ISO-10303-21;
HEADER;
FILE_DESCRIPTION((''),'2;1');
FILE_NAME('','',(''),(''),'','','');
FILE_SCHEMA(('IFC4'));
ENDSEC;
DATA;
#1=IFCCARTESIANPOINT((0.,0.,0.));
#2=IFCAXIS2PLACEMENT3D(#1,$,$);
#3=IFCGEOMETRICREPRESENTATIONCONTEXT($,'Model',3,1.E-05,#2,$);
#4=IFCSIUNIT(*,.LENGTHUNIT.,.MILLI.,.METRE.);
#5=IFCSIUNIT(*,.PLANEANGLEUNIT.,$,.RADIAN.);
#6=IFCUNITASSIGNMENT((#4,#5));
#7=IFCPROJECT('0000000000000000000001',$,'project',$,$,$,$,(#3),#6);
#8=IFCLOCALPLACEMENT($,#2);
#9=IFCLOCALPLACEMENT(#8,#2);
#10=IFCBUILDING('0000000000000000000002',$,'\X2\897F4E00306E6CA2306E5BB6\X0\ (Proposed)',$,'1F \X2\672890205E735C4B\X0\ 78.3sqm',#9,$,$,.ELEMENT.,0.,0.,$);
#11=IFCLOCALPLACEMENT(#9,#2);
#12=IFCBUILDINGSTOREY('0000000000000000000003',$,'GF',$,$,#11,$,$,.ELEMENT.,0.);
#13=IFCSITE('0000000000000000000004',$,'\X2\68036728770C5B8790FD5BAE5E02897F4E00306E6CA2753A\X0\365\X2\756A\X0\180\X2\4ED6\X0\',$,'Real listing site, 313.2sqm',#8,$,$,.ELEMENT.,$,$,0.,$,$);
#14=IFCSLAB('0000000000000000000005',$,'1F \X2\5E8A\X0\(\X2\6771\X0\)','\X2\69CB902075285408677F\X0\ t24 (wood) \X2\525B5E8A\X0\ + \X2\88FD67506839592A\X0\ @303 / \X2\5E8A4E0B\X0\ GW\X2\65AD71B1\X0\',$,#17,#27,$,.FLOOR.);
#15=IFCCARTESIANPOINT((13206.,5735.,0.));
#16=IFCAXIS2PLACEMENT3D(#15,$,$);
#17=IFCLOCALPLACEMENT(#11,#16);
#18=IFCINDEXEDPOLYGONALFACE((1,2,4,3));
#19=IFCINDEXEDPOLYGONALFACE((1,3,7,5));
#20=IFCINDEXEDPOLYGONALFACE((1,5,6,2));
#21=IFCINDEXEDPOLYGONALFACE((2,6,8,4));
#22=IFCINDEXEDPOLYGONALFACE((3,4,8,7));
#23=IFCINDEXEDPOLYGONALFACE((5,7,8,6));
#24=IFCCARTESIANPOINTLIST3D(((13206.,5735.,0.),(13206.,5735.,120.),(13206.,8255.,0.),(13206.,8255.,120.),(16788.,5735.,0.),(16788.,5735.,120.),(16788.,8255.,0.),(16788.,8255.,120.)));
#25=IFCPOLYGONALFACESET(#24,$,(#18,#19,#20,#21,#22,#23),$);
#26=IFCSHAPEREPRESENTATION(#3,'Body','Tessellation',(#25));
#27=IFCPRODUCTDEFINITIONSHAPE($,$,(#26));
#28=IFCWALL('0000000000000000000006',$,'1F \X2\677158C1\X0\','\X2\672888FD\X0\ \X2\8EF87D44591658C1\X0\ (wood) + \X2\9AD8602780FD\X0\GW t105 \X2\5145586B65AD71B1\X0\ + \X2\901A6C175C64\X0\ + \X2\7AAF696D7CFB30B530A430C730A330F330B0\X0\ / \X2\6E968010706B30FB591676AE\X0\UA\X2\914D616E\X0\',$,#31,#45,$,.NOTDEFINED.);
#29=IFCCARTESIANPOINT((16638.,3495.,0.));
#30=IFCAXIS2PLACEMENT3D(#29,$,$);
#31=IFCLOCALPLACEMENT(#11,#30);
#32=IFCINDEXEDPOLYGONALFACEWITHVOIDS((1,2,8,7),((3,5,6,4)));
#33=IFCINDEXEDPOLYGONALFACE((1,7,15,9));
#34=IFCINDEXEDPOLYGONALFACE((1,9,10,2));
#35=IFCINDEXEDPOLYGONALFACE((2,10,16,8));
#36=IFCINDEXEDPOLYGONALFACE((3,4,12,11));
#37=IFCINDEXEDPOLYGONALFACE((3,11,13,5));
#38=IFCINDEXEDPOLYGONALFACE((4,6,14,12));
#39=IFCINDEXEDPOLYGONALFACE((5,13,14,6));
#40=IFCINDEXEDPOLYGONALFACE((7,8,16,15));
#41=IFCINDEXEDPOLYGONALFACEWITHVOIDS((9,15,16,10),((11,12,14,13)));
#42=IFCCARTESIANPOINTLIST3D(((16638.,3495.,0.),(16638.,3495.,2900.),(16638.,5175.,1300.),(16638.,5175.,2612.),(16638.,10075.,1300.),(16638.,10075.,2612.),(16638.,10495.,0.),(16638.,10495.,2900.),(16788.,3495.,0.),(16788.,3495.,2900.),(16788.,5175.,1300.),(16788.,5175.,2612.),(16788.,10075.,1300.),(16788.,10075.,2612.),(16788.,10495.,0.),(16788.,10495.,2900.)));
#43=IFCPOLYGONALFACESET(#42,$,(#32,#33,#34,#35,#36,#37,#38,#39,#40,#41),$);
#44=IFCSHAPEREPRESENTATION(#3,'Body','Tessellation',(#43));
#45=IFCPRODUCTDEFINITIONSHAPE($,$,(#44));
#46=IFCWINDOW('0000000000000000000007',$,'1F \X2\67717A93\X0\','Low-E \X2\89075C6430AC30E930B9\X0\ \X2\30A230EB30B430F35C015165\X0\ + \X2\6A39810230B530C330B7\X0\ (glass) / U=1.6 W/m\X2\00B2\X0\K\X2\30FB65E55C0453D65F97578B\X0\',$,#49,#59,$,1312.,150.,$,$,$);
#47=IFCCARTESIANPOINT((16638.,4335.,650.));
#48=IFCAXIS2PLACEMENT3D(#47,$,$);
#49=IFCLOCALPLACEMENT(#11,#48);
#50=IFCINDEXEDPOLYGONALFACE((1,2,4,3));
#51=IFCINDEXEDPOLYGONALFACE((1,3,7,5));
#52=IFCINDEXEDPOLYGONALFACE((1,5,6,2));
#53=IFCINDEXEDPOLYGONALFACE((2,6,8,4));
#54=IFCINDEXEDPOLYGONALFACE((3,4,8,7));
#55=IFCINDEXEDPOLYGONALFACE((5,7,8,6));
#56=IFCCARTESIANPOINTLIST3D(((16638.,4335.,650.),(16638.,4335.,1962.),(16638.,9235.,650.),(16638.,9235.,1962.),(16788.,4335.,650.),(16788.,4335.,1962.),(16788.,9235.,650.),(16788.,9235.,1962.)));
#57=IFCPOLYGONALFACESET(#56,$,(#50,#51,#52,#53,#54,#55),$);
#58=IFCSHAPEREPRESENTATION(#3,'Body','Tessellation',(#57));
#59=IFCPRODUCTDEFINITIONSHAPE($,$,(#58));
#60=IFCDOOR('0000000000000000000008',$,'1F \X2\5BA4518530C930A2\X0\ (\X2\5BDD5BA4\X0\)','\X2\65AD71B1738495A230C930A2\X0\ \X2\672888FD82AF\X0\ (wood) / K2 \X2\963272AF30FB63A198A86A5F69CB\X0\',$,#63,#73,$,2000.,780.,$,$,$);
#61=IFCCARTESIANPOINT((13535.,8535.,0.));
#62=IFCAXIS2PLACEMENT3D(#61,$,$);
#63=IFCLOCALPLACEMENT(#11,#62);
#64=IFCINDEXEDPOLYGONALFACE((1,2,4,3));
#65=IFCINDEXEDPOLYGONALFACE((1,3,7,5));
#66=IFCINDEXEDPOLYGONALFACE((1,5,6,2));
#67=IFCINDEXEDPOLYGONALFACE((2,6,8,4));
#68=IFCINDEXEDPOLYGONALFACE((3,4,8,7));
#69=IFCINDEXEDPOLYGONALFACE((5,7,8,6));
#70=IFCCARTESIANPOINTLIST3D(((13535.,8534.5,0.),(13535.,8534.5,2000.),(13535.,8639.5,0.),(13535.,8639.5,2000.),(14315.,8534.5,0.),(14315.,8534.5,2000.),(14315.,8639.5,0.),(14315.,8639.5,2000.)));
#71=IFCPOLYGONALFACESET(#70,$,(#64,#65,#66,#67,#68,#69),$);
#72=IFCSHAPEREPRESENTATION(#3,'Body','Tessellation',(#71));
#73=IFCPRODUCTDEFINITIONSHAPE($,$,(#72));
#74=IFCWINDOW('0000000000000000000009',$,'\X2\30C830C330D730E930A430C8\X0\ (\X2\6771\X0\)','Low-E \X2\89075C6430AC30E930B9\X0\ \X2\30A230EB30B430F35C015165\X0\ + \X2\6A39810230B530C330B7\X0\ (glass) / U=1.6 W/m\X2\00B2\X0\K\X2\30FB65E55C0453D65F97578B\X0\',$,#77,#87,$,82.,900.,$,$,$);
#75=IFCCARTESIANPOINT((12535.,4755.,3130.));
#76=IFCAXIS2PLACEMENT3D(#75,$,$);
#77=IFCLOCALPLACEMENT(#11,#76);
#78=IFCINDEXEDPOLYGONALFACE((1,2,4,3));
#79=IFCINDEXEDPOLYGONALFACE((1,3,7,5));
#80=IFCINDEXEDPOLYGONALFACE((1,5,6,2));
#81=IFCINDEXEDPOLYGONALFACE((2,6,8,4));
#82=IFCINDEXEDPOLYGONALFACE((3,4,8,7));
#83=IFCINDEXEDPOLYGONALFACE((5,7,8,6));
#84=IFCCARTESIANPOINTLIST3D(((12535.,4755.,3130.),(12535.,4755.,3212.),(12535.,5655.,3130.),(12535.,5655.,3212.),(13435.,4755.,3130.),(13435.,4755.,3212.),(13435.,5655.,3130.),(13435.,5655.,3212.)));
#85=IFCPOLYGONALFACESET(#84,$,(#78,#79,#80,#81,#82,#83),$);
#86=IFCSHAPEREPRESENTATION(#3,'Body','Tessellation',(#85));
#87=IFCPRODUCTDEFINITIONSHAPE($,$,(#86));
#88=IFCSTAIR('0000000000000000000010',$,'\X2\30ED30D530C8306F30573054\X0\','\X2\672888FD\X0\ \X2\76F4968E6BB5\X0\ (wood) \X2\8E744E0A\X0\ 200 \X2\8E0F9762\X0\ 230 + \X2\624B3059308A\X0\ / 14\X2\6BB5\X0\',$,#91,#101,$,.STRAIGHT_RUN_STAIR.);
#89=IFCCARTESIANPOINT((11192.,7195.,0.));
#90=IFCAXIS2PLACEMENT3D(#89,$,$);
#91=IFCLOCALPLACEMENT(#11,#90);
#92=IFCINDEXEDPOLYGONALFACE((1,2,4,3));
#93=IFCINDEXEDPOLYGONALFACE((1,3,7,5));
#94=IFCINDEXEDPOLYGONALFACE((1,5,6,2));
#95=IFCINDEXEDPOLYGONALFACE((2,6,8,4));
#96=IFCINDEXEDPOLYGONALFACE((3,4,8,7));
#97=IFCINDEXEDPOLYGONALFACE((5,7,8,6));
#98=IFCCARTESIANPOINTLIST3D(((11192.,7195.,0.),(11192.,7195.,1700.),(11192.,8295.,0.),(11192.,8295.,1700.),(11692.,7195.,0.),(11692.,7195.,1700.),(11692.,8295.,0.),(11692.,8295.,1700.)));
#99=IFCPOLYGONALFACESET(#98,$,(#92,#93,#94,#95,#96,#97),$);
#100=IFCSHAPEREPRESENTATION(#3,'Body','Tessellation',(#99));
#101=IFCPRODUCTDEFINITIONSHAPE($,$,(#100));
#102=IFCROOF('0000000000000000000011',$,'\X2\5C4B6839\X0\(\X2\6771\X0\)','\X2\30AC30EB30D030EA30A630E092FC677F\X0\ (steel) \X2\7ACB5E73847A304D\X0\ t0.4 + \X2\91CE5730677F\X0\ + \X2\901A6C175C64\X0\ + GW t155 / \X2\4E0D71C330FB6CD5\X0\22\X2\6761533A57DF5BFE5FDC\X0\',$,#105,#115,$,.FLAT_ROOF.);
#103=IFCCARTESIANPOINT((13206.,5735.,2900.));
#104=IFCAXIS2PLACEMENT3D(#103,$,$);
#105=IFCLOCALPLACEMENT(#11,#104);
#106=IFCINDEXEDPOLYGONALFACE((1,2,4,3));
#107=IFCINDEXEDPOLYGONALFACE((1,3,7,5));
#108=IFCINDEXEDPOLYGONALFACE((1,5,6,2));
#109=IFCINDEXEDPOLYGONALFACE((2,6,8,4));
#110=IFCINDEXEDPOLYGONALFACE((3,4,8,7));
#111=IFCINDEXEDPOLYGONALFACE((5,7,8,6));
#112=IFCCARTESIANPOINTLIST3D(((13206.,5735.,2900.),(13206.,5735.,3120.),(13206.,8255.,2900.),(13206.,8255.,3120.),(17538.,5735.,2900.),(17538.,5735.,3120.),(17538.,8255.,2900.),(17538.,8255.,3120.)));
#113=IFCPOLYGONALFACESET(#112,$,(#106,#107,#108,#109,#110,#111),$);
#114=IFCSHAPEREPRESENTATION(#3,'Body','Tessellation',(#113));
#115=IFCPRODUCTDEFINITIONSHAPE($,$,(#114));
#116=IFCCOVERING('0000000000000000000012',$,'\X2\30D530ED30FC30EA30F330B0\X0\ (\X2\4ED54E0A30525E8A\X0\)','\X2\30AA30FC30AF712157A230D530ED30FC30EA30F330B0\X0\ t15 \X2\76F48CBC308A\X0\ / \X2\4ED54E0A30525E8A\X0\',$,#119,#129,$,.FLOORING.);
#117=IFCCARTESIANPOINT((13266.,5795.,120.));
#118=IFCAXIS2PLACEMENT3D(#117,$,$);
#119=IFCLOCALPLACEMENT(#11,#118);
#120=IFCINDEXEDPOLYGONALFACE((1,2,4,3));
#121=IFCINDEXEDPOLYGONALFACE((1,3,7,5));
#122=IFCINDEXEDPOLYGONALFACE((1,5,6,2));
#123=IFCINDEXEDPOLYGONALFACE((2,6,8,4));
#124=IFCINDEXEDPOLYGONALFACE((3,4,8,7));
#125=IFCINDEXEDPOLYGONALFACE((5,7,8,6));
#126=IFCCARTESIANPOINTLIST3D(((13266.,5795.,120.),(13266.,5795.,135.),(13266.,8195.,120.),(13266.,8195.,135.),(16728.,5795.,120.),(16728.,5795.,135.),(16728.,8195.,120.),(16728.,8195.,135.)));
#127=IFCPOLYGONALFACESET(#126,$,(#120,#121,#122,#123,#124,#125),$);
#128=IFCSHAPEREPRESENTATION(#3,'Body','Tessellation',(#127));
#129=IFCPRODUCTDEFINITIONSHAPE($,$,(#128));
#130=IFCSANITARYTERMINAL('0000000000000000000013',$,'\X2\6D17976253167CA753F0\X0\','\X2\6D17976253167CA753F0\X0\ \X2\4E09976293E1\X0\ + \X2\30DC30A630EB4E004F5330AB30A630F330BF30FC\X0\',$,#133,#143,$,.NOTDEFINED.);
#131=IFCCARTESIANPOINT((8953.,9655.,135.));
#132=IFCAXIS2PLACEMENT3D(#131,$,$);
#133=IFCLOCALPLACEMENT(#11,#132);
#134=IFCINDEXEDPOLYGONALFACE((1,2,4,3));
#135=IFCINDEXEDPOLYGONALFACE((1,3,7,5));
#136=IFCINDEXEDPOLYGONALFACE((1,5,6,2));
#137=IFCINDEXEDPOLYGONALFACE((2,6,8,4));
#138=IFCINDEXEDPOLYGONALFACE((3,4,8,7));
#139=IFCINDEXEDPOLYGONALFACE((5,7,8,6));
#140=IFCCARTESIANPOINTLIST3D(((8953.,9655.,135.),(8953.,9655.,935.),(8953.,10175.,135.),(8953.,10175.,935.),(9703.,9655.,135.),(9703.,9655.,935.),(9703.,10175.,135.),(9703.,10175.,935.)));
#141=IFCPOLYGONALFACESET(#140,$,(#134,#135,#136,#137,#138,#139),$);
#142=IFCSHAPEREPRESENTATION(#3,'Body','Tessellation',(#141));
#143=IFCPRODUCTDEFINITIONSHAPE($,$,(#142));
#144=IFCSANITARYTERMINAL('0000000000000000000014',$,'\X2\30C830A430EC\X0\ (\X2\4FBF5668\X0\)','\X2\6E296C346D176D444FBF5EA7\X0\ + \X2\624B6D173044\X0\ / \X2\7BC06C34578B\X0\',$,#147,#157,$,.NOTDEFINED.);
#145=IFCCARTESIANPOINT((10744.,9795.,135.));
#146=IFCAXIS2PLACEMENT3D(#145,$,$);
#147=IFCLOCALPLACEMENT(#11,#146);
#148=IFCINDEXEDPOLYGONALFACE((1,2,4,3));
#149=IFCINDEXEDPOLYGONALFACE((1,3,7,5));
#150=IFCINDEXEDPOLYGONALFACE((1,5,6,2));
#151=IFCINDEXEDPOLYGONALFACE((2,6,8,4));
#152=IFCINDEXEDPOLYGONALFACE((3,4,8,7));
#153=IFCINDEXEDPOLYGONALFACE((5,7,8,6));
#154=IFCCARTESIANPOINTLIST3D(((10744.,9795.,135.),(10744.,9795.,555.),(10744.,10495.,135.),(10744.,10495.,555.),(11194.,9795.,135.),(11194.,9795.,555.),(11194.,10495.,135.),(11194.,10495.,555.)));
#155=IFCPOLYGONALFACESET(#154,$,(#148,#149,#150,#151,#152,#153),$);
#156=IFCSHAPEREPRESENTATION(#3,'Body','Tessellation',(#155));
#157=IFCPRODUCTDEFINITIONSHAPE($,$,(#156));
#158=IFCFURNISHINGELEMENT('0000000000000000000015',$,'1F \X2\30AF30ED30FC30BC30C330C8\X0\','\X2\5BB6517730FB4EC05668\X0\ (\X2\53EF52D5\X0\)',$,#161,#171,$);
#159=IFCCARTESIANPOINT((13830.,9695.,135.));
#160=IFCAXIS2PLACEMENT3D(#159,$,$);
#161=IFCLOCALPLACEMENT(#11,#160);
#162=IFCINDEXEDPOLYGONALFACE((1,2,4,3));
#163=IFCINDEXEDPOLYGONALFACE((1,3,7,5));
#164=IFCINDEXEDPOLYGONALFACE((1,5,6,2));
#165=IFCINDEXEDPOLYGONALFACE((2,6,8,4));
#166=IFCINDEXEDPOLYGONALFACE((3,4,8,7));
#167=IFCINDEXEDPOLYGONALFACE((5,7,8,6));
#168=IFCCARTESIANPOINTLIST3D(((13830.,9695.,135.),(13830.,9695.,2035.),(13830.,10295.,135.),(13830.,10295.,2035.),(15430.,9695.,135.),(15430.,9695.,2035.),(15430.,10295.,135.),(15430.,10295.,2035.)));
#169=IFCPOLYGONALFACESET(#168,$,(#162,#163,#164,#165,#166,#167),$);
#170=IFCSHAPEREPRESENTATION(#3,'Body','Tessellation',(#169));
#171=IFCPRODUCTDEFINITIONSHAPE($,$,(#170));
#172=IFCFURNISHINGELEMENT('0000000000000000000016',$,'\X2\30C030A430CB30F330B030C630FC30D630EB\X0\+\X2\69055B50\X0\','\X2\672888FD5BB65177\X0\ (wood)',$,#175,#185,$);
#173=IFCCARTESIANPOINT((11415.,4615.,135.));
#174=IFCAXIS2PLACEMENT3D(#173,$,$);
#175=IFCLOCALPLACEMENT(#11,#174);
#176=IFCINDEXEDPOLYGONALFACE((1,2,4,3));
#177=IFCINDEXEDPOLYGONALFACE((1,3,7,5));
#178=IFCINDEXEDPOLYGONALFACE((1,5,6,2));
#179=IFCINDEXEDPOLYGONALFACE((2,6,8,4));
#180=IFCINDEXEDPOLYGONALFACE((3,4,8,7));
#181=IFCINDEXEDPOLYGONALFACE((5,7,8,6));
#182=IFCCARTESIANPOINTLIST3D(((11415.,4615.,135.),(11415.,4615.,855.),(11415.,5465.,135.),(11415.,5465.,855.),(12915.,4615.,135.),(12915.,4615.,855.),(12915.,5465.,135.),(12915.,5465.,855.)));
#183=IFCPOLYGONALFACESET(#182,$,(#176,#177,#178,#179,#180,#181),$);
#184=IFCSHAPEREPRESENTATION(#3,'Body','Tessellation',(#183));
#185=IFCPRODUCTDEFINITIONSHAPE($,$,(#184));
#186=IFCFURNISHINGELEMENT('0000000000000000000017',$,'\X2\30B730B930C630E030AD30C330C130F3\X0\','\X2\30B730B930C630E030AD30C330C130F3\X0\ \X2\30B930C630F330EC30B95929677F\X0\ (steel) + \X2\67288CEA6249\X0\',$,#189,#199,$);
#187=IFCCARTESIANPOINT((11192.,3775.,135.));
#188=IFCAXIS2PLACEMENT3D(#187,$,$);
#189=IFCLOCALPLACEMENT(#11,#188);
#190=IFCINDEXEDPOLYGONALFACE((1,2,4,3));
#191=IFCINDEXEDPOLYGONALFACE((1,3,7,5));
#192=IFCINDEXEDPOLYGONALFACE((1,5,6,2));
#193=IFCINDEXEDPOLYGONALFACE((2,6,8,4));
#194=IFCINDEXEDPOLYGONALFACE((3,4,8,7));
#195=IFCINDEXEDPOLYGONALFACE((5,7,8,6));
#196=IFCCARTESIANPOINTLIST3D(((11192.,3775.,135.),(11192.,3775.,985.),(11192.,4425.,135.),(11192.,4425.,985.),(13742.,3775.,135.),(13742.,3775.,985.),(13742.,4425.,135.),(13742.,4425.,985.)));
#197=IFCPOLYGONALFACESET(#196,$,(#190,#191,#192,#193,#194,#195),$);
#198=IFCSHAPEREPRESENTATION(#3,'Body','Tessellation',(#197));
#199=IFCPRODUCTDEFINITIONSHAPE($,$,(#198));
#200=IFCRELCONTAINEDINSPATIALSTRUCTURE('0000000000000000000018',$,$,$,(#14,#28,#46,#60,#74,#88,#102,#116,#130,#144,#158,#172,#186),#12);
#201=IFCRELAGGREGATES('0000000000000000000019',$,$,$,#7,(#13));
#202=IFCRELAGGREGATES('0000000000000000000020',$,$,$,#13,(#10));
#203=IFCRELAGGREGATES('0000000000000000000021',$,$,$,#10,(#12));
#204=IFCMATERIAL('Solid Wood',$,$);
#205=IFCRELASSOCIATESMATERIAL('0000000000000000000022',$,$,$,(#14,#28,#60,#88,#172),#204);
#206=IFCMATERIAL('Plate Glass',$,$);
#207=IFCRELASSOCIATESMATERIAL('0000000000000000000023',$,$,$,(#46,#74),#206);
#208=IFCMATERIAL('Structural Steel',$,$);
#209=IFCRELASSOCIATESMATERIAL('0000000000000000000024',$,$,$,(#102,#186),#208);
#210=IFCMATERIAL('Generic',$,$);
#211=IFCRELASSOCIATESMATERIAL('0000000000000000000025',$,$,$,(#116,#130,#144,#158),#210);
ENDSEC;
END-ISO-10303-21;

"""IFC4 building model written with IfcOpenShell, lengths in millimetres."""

from ifc_helpers import new_model, si_unit, frame, frame_2d, origin, place, context, project, spatial, rectangle, extrude, material, element, fill, save


model = new_model("IFC4")

# Units and contexts
model_context = context("Model", 3, precision=1e-05, world=origin())
ifc_project = project(units=[si_unit("LENGTHUNIT", "METRE", prefix="MILLI"), si_unit("PLANEANGLEUNIT", "RADIAN")], contexts=[model_context])

# Site, building, storey
site_placement = place(None, origin())
site = spatial("IfcSite", under=ifc_project, at=site_placement, Name="栃木県宇都宮市西一の沢町365番180他", ObjectType="Real listing site, 313.2sqm", CompositionType="ELEMENT", RefElevation=0.0)
building_placement = place(site_placement, origin())
building = spatial("IfcBuilding", under=site, at=building_placement, Name="西一の沢の家 (Proposed)", ObjectType="1F 木造平屋 78.3sqm", CompositionType="ELEMENT", ElevationOfRefHeight=0.0, ElevationOfTerrain=0.0)
storey_placement = place(building_placement, origin())
storey = spatial("IfcBuildingStorey", under=building, at=storey_placement, Name="GF", CompositionType="ELEMENT", Elevation=0.0)

# Slab
ifc_material_1 = material(Name="Solid Wood")
slab_1_placement = place(storey_placement, frame((13206.0, 5735.0, 0.0)))
element("IfcSlab", 1, at=slab_1_placement, inside=storey, material=ifc_material_1, Name="1F 床(東)", Description="構造用合板 t24 (wood) 剛床 + 製材根太 @303 / 床下 GW断熱", PredefinedType="FLOOR", context=model_context, shape_type="SweptSolid", body=[
    extrude(rectangle(XDim=3582.0, YDim=2520.0, at=frame_2d((1791.0, 1260.0))), frame((13206.0, 5735.0, 0.0)), (0.0, 0.0, 1.0), 120.0),
])

# Wall, opening, window
wall_1_placement = place(storey_placement, frame((16638.0, 3495.0, 0.0)))
wall_1 = element("IfcWall", 2, at=wall_1_placement, inside=storey, material=ifc_material_1, Name="1F 東壁", Description="木製 軸組外壁 (wood) + 高性能GW t105 充填断熱 + 通気層 + 窯業系サイディング / 準耐火・外皮UA配慮", PredefinedType="NOTDEFINED", context=model_context, shape_type="SweptSolid", body=[
    extrude(rectangle(XDim=150.0, YDim=7000.0, at=frame_2d((75.0, 3500.0))), frame((16638.0, 3495.0, 0.0)), (0.0, 0.0, 1.0), 2900.0),
])
opening_1_placement = place(storey_placement, frame((16638.0, 4335.0, 650.0)))
opening_1 = element("IfcOpeningElement", 3, at=opening_1_placement, cuts=wall_1, PredefinedType="NOTDEFINED", context=model_context, shape_type="SweptSolid", body=[
    extrude(rectangle(XDim=150.0, YDim=4900.0, at=frame_2d((75.0, 2450.0))), frame((16638.0, 4335.0, 650.0)), (0.0, 0.0, 1.0), 1312.0),
])
ifc_material_2 = material(Name="Plate Glass")
window_1_placement = place(storey_placement, frame((16638.0, 4335.0, 650.0)))
window_1 = element("IfcWindow", 4, at=window_1_placement, inside=storey, material=ifc_material_2, Name="1F 東窓", Description="Low-E 複層ガラス アルゴン封入 + 樹脂サッシ (glass) / U=1.6 W/m²K・日射取得型", OverallHeight=1312.0, OverallWidth=150.0, context=model_context, shape_type="SweptSolid", body=[
    extrude(rectangle(XDim=150.0, YDim=4900.0, at=frame_2d((75.0, 2450.0))), frame((16638.0, 4335.0, 650.0)), (0.0, 0.0, 1.0), 1312.0),
])
fill(opening_1, window_1)

# Door
door_placement = place(storey_placement, frame((13535.0, 8535.0, 0.0)))
element("IfcDoor", 5, at=door_placement, inside=storey, material=ifc_material_1, Name="1F 室内ドア (寝室)", Description="断熱玄関ドア 木製芯 (wood) / K2 防犯・採風機構", OverallHeight=2000.0, OverallWidth=780.0, context=model_context, shape_type="SweptSolid", body=[
    extrude(rectangle(XDim=780.0, YDim=105.0, at=frame_2d((390.0, 52.0))), frame((13535.0, 8535.0, 0.0)), (0.0, 0.0, 1.0), 2000.0),
])

# Window
window_2_placement = place(storey_placement, frame((12535.0, 4755.0, 3130.0)))
element("IfcWindow", 6, at=window_2_placement, inside=storey, material=ifc_material_2, Name="トップライト (東)", Description="Low-E 複層ガラス アルゴン封入 + 樹脂サッシ (glass) / U=1.6 W/m²K・日射取得型", OverallHeight=82.0, OverallWidth=900.0, context=model_context, shape_type="SweptSolid", body=[
    extrude(rectangle(XDim=900.0, YDim=900.0, at=frame_2d((450.0, 450.0))), frame((12535.0, 4755.0, 3130.0)), (0.0, 0.0, 1.0), 82.0),
])

# Stair
stair_placement = place(storey_placement, frame((11192.0, 7195.0, 0.0)))
element("IfcStair", 7, at=stair_placement, inside=storey, material=ifc_material_1, Name="ロフトはしご", Description="木製 直階段 (wood) 蹴上 200 踏面 230 + 手すり / 14段", PredefinedType="STRAIGHT_RUN_STAIR", context=model_context, shape_type="SweptSolid", body=[
    extrude(rectangle(XDim=500.0, YDim=1100.0, at=frame_2d((250.0, 550.0))), frame((11192.0, 7195.0, 0.0)), (0.0, 0.0, 1.0), 1700.0),
])

# Roof
ifc_material_3 = material(Name="Structural Steel")
roof_placement = place(storey_placement, frame((13206.0, 5735.0, 2900.0)))
element("IfcRoof", 8, at=roof_placement, inside=storey, material=ifc_material_3, Name="屋根(東)", Description="ガルバリウム鋼板 (steel) 立平葺き t0.4 + 野地板 + 通気層 + GW t155 / 不燃・法22条区域対応", PredefinedType="FLAT_ROOF", context=model_context, shape_type="SweptSolid", body=[
    extrude(rectangle(XDim=4332.0, YDim=2520.0, at=frame_2d((2166.0, 1260.0))), frame((13206.0, 5735.0, 2900.0)), (0.0, 0.0, 1.0), 220.0),
])

# Covering
ifc_material_4 = material(Name="Generic")
covering_placement = place(storey_placement, frame((13266.0, 5795.0, 120.0)))
element("IfcCovering", 9, at=covering_placement, inside=storey, material=ifc_material_4, Name="フローリング (仕上げ床)", Description="オーク無垢フローリング t15 直貼り / 仕上げ床", PredefinedType="FLOORING", context=model_context, shape_type="SweptSolid", body=[
    extrude(rectangle(XDim=3462.0, YDim=2400.0, at=frame_2d((1731.0, 1200.0))), frame((13266.0, 5795.0, 120.0)), (0.0, 0.0, 1.0), 15.0),
])

# Sanitary terminals
sanitary_terminal_1_placement = place(storey_placement, frame((8953.0, 9655.0, 135.0)))
element("IfcSanitaryTerminal", 10, at=sanitary_terminal_1_placement, inside=storey, material=ifc_material_4, Name="洗面化粧台", Description="洗面化粧台 三面鏡 + ボウル一体カウンター", PredefinedType="NOTDEFINED", context=model_context, shape_type="SweptSolid", body=[
    extrude(rectangle(XDim=750.0, YDim=520.0, at=frame_2d((375.0, 260.0))), frame((8953.0, 9655.0, 135.0)), (0.0, 0.0, 1.0), 800.0),
])
sanitary_terminal_2_placement = place(storey_placement, frame((10744.0, 9795.0, 135.0)))
element("IfcSanitaryTerminal", 11, at=sanitary_terminal_2_placement, inside=storey, material=ifc_material_4, Name="トイレ (便器)", Description="温水洗浄便座 + 手洗い / 節水型", PredefinedType="NOTDEFINED", context=model_context, shape_type="SweptSolid", body=[
    extrude(rectangle(XDim=450.0, YDim=700.0, at=frame_2d((225.0, 350.0))), frame((10744.0, 9795.0, 135.0)), (0.0, 0.0, 1.0), 420.0),
])

# Furnishing elements
furnishing_1_placement = place(storey_placement, frame((13830.0, 9695.0, 135.0)))
element("IfcFurnishingElement", 12, at=furnishing_1_placement, inside=storey, material=ifc_material_4, Name="1F クローゼット", Description="家具・什器 (可動)", context=model_context, shape_type="SweptSolid", body=[
    extrude(rectangle(XDim=1600.0, YDim=600.0, at=frame_2d((800.0, 300.0))), frame((13830.0, 9695.0, 135.0)), (0.0, 0.0, 1.0), 1900.0),
])
furnishing_2_placement = place(storey_placement, frame((11415.0, 4615.0, 135.0)))
element("IfcFurnishingElement", 13, at=furnishing_2_placement, inside=storey, material=ifc_material_1, Name="ダイニングテーブル+椅子", Description="木製家具 (wood)", context=model_context, shape_type="SweptSolid", body=[
    extrude(rectangle(XDim=1500.0, YDim=850.0, at=frame_2d((750.0, 425.0))), frame((11415.0, 4615.0, 135.0)), (0.0, 0.0, 1.0), 720.0),
])
furnishing_3_placement = place(storey_placement, frame((11192.0, 3775.0, 135.0)))
element("IfcFurnishingElement", 14, at=furnishing_3_placement, inside=storey, material=ifc_material_3, Name="システムキッチン", Description="システムキッチン ステンレス天板 (steel) + 木質扉", context=model_context, shape_type="SweptSolid", body=[
    extrude(rectangle(XDim=2550.0, YDim=650.0, at=frame_2d((1275.0, 325.0))), frame((11192.0, 3775.0, 135.0)), (0.0, 0.0, 1.0), 850.0),
])

save(model, "model.ifc")
